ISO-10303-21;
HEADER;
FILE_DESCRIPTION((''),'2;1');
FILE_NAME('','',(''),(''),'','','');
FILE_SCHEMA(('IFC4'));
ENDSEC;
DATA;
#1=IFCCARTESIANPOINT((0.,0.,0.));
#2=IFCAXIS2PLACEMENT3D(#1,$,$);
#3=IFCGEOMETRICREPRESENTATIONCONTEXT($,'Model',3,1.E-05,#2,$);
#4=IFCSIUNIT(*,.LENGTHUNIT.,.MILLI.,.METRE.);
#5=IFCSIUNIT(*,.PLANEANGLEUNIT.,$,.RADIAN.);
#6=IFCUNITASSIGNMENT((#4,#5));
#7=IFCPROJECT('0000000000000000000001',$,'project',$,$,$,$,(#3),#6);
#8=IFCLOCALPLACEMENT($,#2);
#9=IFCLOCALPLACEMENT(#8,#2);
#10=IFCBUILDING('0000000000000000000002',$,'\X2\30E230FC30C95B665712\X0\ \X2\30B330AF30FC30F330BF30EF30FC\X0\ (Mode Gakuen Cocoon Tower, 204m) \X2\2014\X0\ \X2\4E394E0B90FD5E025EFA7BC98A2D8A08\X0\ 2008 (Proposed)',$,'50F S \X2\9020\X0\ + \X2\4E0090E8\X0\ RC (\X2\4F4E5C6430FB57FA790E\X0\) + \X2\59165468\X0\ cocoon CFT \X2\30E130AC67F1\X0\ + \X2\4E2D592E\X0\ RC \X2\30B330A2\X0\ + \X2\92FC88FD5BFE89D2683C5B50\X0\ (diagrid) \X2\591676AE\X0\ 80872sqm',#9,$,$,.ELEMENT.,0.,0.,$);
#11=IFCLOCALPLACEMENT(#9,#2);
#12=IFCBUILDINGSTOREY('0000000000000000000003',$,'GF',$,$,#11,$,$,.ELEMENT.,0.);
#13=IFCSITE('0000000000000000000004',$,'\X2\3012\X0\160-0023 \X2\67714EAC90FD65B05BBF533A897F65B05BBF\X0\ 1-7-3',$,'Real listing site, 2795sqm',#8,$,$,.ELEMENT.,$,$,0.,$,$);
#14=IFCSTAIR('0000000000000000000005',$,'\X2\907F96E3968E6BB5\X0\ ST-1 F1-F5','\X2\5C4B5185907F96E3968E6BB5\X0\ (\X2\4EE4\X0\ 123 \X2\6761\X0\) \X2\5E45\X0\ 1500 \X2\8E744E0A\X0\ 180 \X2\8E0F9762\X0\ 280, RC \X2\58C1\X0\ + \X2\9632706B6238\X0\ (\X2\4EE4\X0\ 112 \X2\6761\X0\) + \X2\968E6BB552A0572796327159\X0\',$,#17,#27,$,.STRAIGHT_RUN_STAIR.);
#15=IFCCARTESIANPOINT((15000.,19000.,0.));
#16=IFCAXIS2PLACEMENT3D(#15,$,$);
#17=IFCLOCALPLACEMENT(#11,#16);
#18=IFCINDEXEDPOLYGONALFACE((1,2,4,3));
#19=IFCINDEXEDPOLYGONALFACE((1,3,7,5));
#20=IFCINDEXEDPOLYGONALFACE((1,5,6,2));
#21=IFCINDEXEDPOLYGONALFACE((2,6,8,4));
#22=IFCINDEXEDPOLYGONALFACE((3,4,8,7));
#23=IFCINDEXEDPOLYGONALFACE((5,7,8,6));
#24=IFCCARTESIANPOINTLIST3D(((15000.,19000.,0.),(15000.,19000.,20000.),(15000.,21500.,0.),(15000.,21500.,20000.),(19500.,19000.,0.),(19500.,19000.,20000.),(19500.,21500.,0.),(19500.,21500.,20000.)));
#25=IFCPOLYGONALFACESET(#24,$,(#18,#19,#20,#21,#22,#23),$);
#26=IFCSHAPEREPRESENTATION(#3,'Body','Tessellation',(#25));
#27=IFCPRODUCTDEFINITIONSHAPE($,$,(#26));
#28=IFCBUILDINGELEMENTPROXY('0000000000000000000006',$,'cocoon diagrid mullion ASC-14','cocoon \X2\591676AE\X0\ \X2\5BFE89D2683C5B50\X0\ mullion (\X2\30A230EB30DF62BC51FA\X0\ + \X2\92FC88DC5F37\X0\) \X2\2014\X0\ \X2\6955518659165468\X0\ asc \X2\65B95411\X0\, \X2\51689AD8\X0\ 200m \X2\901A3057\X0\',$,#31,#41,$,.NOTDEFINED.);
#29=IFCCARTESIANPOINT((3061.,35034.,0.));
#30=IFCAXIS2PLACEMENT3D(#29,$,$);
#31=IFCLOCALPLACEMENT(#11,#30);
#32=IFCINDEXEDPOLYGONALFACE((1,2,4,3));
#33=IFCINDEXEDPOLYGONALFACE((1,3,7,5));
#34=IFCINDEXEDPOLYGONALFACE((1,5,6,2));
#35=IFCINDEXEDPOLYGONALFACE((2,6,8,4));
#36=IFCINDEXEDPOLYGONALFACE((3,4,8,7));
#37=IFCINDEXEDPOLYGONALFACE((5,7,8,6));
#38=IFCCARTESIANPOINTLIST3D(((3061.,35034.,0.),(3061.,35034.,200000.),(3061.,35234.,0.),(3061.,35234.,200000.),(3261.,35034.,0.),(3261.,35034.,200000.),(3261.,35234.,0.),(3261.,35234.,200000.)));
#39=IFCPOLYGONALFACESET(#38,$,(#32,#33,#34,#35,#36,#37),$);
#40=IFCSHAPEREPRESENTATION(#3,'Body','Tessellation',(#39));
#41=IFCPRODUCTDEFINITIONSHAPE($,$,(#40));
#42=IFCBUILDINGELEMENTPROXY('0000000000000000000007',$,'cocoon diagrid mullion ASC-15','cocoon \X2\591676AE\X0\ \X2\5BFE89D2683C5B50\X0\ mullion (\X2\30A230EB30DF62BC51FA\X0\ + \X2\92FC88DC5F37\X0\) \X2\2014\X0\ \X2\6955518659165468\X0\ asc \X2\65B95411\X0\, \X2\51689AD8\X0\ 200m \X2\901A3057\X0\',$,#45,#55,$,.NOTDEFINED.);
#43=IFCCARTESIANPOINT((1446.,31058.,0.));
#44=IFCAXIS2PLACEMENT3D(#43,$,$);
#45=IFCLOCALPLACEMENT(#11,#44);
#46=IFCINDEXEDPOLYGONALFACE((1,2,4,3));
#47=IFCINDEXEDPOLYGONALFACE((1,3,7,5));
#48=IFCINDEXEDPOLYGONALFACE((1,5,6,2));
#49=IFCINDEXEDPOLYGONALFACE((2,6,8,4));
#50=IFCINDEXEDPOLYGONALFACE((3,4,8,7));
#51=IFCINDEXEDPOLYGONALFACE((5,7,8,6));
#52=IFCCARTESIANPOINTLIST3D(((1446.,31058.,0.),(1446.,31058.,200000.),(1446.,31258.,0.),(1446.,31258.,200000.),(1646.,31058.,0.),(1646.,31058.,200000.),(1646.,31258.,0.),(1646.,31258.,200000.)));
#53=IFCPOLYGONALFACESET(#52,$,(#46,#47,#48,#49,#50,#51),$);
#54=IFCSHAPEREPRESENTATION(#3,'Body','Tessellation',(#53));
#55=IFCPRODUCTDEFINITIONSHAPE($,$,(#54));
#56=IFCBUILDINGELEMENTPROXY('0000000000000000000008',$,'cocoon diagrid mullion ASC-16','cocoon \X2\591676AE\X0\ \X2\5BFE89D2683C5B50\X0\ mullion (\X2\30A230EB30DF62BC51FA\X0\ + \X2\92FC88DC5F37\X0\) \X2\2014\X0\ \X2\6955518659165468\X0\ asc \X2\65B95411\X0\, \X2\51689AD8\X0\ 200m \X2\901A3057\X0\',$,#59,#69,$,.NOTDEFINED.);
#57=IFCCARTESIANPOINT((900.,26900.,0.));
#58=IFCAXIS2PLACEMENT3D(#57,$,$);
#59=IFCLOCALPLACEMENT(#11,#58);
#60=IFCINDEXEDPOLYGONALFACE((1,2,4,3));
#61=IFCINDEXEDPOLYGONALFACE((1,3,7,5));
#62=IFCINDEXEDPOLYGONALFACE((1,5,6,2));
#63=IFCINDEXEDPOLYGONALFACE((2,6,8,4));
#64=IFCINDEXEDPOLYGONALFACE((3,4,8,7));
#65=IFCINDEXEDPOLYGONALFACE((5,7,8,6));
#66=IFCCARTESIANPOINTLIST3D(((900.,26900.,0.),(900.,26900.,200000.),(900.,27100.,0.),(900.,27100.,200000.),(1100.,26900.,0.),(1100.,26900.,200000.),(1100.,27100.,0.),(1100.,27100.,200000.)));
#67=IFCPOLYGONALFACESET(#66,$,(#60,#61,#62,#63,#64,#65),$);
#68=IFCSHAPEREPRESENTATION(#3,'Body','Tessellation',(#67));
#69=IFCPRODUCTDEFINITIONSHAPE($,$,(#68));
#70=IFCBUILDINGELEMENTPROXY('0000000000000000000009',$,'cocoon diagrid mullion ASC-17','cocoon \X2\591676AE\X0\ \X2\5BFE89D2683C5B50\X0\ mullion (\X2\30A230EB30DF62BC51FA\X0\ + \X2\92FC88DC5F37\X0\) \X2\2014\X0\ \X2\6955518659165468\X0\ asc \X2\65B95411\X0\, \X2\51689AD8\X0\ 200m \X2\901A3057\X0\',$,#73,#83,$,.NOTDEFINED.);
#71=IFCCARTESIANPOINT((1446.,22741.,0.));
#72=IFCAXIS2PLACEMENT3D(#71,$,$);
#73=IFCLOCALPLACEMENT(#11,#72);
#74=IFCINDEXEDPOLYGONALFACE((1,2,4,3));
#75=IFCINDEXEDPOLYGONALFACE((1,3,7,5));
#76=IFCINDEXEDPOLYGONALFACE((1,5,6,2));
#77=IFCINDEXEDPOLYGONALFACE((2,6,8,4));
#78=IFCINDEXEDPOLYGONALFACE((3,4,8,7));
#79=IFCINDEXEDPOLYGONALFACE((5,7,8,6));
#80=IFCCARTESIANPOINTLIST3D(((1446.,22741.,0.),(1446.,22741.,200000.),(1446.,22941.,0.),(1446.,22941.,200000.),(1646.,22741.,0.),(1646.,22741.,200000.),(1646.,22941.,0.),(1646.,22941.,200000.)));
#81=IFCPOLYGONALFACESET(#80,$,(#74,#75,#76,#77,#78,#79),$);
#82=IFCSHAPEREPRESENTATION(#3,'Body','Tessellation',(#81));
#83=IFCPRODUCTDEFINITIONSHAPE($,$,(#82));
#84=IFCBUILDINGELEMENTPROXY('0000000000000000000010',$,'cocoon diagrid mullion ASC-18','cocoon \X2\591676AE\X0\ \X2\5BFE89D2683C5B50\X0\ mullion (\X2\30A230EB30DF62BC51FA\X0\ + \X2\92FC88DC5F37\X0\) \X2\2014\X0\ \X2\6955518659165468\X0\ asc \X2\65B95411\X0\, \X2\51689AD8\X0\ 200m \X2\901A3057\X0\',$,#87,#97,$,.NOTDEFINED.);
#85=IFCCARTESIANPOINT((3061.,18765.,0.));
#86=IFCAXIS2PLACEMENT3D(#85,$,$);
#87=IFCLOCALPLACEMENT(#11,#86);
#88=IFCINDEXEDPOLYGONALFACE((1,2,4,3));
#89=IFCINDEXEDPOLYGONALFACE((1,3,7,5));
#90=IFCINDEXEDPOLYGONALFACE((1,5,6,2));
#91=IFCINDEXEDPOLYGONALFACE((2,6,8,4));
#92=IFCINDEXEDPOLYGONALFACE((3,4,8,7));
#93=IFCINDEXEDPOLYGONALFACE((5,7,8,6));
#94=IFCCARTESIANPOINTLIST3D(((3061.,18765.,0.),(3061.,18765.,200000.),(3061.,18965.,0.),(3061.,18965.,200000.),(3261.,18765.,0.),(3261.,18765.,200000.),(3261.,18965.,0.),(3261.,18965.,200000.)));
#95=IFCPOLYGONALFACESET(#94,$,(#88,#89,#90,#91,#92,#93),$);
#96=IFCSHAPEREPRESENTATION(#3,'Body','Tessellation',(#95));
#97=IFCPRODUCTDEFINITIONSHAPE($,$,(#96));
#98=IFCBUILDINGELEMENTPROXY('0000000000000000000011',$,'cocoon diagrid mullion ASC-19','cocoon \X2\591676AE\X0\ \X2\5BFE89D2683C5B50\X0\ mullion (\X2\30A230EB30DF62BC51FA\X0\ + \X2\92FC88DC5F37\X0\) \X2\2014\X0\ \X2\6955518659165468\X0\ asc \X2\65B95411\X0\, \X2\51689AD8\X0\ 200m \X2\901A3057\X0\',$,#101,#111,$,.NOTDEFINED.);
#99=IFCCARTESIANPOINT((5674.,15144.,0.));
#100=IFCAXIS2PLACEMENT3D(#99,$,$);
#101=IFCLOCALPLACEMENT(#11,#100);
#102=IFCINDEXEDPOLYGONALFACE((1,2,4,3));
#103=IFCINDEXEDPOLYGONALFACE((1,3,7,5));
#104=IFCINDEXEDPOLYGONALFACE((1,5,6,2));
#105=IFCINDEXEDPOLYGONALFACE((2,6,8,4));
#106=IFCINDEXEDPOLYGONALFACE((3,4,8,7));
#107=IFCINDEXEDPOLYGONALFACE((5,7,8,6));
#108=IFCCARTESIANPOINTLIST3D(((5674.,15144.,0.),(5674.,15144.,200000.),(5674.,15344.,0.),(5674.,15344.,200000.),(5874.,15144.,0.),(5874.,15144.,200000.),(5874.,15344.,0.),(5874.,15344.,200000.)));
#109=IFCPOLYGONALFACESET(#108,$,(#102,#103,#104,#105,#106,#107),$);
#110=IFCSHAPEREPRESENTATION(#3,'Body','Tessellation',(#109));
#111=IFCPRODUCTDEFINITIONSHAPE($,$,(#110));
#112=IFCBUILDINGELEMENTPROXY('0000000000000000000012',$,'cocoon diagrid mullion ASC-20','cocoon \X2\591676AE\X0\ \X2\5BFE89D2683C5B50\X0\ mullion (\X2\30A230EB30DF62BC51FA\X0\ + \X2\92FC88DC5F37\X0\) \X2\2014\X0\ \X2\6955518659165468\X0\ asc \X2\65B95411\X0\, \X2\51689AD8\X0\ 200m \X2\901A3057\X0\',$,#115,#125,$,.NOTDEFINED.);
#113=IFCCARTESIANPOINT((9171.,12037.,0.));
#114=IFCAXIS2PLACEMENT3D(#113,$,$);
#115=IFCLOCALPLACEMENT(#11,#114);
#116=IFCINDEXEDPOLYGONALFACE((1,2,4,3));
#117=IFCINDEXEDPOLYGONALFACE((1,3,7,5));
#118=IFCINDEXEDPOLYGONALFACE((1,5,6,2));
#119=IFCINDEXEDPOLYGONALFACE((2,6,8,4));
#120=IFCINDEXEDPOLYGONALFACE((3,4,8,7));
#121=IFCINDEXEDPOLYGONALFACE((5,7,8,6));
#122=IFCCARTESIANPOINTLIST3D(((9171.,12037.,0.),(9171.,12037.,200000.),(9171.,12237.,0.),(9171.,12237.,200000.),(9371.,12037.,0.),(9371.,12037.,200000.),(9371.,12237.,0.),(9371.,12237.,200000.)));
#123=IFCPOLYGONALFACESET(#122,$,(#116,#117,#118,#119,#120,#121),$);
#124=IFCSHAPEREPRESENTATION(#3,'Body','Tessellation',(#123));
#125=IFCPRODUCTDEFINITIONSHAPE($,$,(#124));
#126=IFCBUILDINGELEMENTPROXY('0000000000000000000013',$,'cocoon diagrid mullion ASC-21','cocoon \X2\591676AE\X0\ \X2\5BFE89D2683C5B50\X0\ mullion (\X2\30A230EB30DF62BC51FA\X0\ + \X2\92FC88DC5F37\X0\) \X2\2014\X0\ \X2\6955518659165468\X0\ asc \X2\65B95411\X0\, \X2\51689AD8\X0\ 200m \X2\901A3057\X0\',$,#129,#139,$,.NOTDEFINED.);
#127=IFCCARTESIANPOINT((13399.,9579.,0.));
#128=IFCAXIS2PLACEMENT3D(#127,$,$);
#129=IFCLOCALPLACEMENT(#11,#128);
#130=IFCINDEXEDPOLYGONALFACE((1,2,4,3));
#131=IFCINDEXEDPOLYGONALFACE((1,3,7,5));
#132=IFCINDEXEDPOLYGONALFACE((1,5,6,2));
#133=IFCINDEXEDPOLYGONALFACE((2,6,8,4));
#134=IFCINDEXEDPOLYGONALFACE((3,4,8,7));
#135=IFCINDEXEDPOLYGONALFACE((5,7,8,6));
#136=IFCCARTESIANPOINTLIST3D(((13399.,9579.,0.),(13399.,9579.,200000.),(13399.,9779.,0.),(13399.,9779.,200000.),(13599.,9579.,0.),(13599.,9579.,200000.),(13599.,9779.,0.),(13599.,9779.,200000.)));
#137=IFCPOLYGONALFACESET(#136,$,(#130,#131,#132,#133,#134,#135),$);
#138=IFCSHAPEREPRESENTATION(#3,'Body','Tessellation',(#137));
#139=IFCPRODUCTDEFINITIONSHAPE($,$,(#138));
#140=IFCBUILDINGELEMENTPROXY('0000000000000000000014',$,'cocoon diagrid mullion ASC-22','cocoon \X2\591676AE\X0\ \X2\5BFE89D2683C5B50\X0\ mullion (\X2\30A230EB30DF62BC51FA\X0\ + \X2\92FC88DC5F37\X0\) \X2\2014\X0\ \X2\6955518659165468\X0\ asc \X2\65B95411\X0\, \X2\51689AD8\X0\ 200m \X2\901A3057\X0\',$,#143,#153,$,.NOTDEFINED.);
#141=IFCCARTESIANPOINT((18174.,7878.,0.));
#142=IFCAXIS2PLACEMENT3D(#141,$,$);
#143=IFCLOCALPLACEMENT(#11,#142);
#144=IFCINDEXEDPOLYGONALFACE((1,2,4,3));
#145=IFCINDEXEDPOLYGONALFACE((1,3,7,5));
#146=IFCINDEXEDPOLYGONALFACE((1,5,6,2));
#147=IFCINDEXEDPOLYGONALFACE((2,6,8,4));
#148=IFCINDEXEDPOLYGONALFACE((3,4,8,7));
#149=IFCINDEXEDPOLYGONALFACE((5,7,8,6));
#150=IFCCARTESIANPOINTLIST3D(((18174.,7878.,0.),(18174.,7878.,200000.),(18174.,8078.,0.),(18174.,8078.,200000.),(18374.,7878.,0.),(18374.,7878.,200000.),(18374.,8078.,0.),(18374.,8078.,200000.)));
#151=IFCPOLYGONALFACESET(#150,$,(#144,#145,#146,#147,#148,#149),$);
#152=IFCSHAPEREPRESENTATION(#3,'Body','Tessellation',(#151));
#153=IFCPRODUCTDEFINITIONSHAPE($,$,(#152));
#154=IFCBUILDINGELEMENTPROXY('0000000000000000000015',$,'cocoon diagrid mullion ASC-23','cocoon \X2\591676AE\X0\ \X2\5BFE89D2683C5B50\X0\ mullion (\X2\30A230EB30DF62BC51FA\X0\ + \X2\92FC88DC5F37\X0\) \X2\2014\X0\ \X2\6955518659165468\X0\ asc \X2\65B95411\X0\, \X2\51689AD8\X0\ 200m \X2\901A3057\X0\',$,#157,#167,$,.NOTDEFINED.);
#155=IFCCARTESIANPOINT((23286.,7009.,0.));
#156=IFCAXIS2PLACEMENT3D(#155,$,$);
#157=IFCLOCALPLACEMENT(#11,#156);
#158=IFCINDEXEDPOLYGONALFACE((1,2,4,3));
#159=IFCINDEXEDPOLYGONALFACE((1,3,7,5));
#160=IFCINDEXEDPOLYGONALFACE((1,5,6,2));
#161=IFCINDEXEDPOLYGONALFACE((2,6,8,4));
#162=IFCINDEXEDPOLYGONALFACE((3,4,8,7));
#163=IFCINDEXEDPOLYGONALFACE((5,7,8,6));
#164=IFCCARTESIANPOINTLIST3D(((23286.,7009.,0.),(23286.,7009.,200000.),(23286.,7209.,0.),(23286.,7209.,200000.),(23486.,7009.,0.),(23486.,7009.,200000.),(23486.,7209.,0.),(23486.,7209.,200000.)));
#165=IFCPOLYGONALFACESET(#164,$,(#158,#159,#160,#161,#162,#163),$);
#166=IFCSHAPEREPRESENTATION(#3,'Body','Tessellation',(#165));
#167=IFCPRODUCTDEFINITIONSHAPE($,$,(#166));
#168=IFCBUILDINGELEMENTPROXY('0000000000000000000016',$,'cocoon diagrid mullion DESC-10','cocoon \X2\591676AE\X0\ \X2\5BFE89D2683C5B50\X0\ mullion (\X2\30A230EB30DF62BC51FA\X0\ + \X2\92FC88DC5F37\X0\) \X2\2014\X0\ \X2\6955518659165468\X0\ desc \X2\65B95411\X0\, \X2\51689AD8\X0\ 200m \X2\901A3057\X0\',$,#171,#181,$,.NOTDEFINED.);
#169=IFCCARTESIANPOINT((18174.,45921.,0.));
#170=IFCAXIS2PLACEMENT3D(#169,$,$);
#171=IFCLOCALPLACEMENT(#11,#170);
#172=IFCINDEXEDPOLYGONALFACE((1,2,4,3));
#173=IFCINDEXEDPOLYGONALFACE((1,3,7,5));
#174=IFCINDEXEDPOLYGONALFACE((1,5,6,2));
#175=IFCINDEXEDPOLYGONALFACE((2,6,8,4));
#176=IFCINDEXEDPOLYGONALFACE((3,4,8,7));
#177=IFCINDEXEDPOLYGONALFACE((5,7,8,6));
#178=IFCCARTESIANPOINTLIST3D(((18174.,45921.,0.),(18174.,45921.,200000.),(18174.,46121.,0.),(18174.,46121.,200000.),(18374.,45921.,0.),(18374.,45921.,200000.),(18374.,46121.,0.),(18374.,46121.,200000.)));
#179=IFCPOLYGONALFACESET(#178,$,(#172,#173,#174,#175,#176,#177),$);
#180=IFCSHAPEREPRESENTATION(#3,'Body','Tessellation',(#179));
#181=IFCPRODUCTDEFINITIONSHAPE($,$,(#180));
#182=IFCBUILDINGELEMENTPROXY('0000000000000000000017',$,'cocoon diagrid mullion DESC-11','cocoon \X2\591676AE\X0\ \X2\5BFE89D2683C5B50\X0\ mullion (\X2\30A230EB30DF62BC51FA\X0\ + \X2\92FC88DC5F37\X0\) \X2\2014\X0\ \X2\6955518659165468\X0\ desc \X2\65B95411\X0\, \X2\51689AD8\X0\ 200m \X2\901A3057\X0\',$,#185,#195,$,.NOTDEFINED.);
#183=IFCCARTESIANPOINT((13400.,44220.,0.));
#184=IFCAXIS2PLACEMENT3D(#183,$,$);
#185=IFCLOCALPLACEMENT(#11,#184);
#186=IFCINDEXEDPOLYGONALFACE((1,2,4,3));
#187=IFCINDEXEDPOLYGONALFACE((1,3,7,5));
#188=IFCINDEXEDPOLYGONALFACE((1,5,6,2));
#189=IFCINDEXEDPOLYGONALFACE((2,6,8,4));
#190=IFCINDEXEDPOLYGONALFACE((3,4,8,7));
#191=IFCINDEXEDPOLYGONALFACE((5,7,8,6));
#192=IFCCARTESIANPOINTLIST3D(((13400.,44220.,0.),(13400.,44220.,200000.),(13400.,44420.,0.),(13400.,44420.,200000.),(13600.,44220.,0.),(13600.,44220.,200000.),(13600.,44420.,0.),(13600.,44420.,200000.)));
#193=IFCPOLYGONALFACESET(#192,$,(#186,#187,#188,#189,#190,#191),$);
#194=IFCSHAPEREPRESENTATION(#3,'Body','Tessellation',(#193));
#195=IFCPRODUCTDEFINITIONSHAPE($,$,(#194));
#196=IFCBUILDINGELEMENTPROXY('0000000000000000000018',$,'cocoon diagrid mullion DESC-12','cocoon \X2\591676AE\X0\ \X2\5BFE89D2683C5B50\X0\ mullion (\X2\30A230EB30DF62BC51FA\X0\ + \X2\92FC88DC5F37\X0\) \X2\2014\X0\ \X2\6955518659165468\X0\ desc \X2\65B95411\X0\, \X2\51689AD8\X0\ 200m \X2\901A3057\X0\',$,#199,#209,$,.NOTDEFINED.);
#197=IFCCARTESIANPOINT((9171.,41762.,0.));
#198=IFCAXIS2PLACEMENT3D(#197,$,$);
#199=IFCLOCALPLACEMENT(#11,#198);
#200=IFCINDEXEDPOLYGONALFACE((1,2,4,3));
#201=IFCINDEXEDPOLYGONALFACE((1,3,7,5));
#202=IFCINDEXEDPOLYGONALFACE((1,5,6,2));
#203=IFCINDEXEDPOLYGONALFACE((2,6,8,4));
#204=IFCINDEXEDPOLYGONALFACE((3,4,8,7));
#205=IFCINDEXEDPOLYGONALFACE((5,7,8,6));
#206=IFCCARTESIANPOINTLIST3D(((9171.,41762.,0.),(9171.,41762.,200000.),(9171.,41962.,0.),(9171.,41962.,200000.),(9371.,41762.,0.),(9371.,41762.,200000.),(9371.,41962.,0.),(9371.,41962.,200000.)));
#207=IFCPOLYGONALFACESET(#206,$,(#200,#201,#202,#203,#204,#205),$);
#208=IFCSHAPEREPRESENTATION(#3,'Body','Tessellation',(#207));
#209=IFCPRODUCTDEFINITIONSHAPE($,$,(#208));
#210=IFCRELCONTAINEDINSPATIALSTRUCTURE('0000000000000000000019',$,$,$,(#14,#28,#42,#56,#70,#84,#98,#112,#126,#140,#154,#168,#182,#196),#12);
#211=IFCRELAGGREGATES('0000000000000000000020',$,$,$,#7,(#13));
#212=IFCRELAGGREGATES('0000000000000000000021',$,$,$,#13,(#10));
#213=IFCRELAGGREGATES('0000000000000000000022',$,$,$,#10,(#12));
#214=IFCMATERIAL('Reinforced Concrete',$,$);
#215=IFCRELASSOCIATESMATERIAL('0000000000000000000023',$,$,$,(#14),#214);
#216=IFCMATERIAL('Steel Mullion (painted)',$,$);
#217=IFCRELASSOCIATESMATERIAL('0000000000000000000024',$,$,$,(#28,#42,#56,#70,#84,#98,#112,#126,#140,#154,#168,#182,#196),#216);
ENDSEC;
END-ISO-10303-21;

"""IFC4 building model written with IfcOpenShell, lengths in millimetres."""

from ifc_helpers import new_model, si_unit, frame, frame_2d, origin, place, context, project, spatial, rectangle, extrude, material, element, save


model = new_model("IFC4")

# Units and contexts
model_context = context("Model", 3, precision=1e-05, world=origin())
ifc_project = project(units=[si_unit("LENGTHUNIT", "METRE", prefix="MILLI"), si_unit("PLANEANGLEUNIT", "RADIAN")], contexts=[model_context])

# Site, building, storey
site_placement = place(None, origin())
site = spatial("IfcSite", under=ifc_project, at=site_placement, Name="〒160-0023 東京都新宿区西新宿 1-7-3", ObjectType="Real listing site, 2795sqm", CompositionType="ELEMENT", RefElevation=0.0)
building_placement = place(site_placement, origin())
building = spatial("IfcBuilding", under=site, at=building_placement, Name="モード学園 コクーンタワー (Mode Gakuen Cocoon Tower, 204m) — 丹下都市建築設計 2008 (Proposed)", ObjectType="50F S 造 + 一部 RC (低層・基礎) + 外周 cocoon CFT メガ柱 + 中央 RC コア + 鋼製対角格子 (diagrid) 外皮 80872sqm", CompositionType="ELEMENT", ElevationOfRefHeight=0.0, ElevationOfTerrain=0.0)
storey_placement = place(building_placement, origin())
storey = spatial("IfcBuildingStorey", under=building, at=storey_placement, Name="GF", CompositionType="ELEMENT", Elevation=0.0)

# Stair
ifc_material_1 = material(Name="Reinforced Concrete")
stair_placement = place(storey_placement, frame((15000.0, 19000.0, 0.0)))
element("IfcStair", 1, at=stair_placement, inside=storey, material=ifc_material_1, Name="避難階段 ST-1 F1-F5", Description="屋内避難階段 (令 123 条) 幅 1500 蹴上 180 踏面 280, RC 壁 + 防火戸 (令 112 条) + 階段加圧防煙", PredefinedType="STRAIGHT_RUN_STAIR", context=model_context, shape_type="SweptSolid", body=[
    extrude(rectangle(XDim=4500.0, YDim=2500.0, at=frame_2d((2250.0, 1250.0))), frame((15000.0, 19000.0, 0.0)), (0.0, 0.0, 1.0), 20000.0),
])

# Building element proxies
ifc_material_2 = material(Name="Steel Mullion (painted)")
proxy_1_placement = place(storey_placement, frame((3061.0, 35034.0, 0.0)))
element("IfcBuildingElementProxy", 2, at=proxy_1_placement, inside=storey, material=ifc_material_2, Name="cocoon diagrid mullion ASC-14", Description="cocoon 外皮 対角格子 mullion (アルミ押出 + 鋼補強) — 楕円外周 asc 方向, 全高 200m 通し", PredefinedType="NOTDEFINED", context=model_context, shape_type="SweptSolid", body=[
    extrude(rectangle(XDim=200.0, YDim=200.0, at=frame_2d((100.0, 100.0))), frame((3061.0, 35034.0, 0.0)), (0.0, 0.0, 1.0), 200000.0),
])
proxy_2_placement = place(storey_placement, frame((1446.0, 31058.0, 0.0)))
element("IfcBuildingElementProxy", 3, at=proxy_2_placement, inside=storey, material=ifc_material_2, Name="cocoon diagrid mullion ASC-15", Description="cocoon 外皮 対角格子 mullion (アルミ押出 + 鋼補強) — 楕円外周 asc 方向, 全高 200m 通し", PredefinedType="NOTDEFINED", context=model_context, shape_type="SweptSolid", body=[
    extrude(rectangle(XDim=200.0, YDim=200.0, at=frame_2d((100.0, 100.0))), frame((1446.0, 31058.0, 0.0)), (0.0, 0.0, 1.0), 200000.0),
])
proxy_3_placement = place(storey_placement, frame((900.0, 26900.0, 0.0)))
element("IfcBuildingElementProxy", 4, at=proxy_3_placement, inside=storey, material=ifc_material_2, Name="cocoon diagrid mullion ASC-16", Description="cocoon 外皮 対角格子 mullion (アルミ押出 + 鋼補強) — 楕円外周 asc 方向, 全高 200m 通し", PredefinedType="NOTDEFINED", context=model_context, shape_type="SweptSolid", body=[
    extrude(rectangle(XDim=200.0, YDim=200.0, at=frame_2d((100.0, 100.0))), frame((900.0, 26900.0, 0.0)), (0.0, 0.0, 1.0), 200000.0),
])
proxy_4_placement = place(storey_placement, frame((1446.0, 22741.0, 0.0)))
element("IfcBuildingElementProxy", 5, at=proxy_4_placement, inside=storey, material=ifc_material_2, Name="cocoon diagrid mullion ASC-17", Description="cocoon 外皮 対角格子 mullion (アルミ押出 + 鋼補強) — 楕円外周 asc 方向, 全高 200m 通し", PredefinedType="NOTDEFINED", context=model_context, shape_type="SweptSolid", body=[
    extrude(rectangle(XDim=200.0, YDim=200.0, at=frame_2d((100.0, 100.0))), frame((1446.0, 22741.0, 0.0)), (0.0, 0.0, 1.0), 200000.0),
])
proxy_5_placement = place(storey_placement, frame((3061.0, 18765.0, 0.0)))
element("IfcBuildingElementProxy", 6, at=proxy_5_placement, inside=storey, material=ifc_material_2, Name="cocoon diagrid mullion ASC-18", Description="cocoon 外皮 対角格子 mullion (アルミ押出 + 鋼補強) — 楕円外周 asc 方向, 全高 200m 通し", PredefinedType="NOTDEFINED", context=model_context, shape_type="SweptSolid", body=[
    extrude(rectangle(XDim=200.0, YDim=200.0, at=frame_2d((100.0, 100.0))), frame((3061.0, 18765.0, 0.0)), (0.0, 0.0, 1.0), 200000.0),
])
proxy_6_placement = place(storey_placement, frame((5674.0, 15144.0, 0.0)))
element("IfcBuildingElementProxy", 7, at=proxy_6_placement, inside=storey, material=ifc_material_2, Name="cocoon diagrid mullion ASC-19", Description="cocoon 外皮 対角格子 mullion (アルミ押出 + 鋼補強) — 楕円外周 asc 方向, 全高 200m 通し", PredefinedType="NOTDEFINED", context=model_context, shape_type="SweptSolid", body=[
    extrude(rectangle(XDim=200.0, YDim=200.0, at=frame_2d((100.0, 100.0))), frame((5674.0, 15144.0, 0.0)), (0.0, 0.0, 1.0), 200000.0),
])
proxy_7_placement = place(storey_placement, frame((9171.0, 12037.0, 0.0)))
element("IfcBuildingElementProxy", 8, at=proxy_7_placement, inside=storey, material=ifc_material_2, Name="cocoon diagrid mullion ASC-20", Description="cocoon 外皮 対角格子 mullion (アルミ押出 + 鋼補強) — 楕円外周 asc 方向, 全高 200m 通し", PredefinedType="NOTDEFINED", context=model_context, shape_type="SweptSolid", body=[
    extrude(rectangle(XDim=200.0, YDim=200.0, at=frame_2d((100.0, 100.0))), frame((9171.0, 12037.0, 0.0)), (0.0, 0.0, 1.0), 200000.0),
])
proxy_8_placement = place(storey_placement, frame((13399.0, 9579.0, 0.0)))
element("IfcBuildingElementProxy", 9, at=proxy_8_placement, inside=storey, material=ifc_material_2, Name="cocoon diagrid mullion ASC-21", Description="cocoon 外皮 対角格子 mullion (アルミ押出 + 鋼補強) — 楕円外周 asc 方向, 全高 200m 通し", PredefinedType="NOTDEFINED", context=model_context, shape_type="SweptSolid", body=[
    extrude(rectangle(XDim=200.0, YDim=200.0, at=frame_2d((100.0, 100.0))), frame((13399.0, 9579.0, 0.0)), (0.0, 0.0, 1.0), 200000.0),
])
proxy_9_placement = place(storey_placement, frame((18174.0, 7878.0, 0.0)))
element("IfcBuildingElementProxy", 10, at=proxy_9_placement, inside=storey, material=ifc_material_2, Name="cocoon diagrid mullion ASC-22", Description="cocoon 外皮 対角格子 mullion (アルミ押出 + 鋼補強) — 楕円外周 asc 方向, 全高 200m 通し", PredefinedType="NOTDEFINED", context=model_context, shape_type="SweptSolid", body=[
    extrude(rectangle(XDim=200.0, YDim=200.0, at=frame_2d((100.0, 100.0))), frame((18174.0, 7878.0, 0.0)), (0.0, 0.0, 1.0), 200000.0),
])
proxy_10_placement = place(storey_placement, frame((23286.0, 7009.0, 0.0)))
element("IfcBuildingElementProxy", 11, at=proxy_10_placement, inside=storey, material=ifc_material_2, Name="cocoon diagrid mullion ASC-23", Description="cocoon 外皮 対角格子 mullion (アルミ押出 + 鋼補強) — 楕円外周 asc 方向, 全高 200m 通し", PredefinedType="NOTDEFINED", context=model_context, shape_type="SweptSolid", body=[
    extrude(rectangle(XDim=200.0, YDim=200.0, at=frame_2d((100.0, 100.0))), frame((23286.0, 7009.0, 0.0)), (0.0, 0.0, 1.0), 200000.0),
])
proxy_11_placement = place(storey_placement, frame((18174.0, 45921.0, 0.0)))
element("IfcBuildingElementProxy", 12, at=proxy_11_placement, inside=storey, material=ifc_material_2, Name="cocoon diagrid mullion DESC-10", Description="cocoon 外皮 対角格子 mullion (アルミ押出 + 鋼補強) — 楕円外周 desc 方向, 全高 200m 通し", PredefinedType="NOTDEFINED", context=model_context, shape_type="SweptSolid", body=[
    extrude(rectangle(XDim=200.0, YDim=200.0, at=frame_2d((100.0, 100.0))), frame((18174.0, 45921.0, 0.0)), (0.0, 0.0, 1.0), 200000.0),
])
proxy_12_placement = place(storey_placement, frame((13400.0, 44220.0, 0.0)))
element("IfcBuildingElementProxy", 13, at=proxy_12_placement, inside=storey, material=ifc_material_2, Name="cocoon diagrid mullion DESC-11", Description="cocoon 外皮 対角格子 mullion (アルミ押出 + 鋼補強) — 楕円外周 desc 方向, 全高 200m 通し", PredefinedType="NOTDEFINED", context=model_context, shape_type="SweptSolid", body=[
    extrude(rectangle(XDim=200.0, YDim=200.0, at=frame_2d((100.0, 100.0))), frame((13400.0, 44220.0, 0.0)), (0.0, 0.0, 1.0), 200000.0),
])
proxy_13_placement = place(storey_placement, frame((9171.0, 41762.0, 0.0)))
element("IfcBuildingElementProxy", 14, at=proxy_13_placement, inside=storey, material=ifc_material_2, Name="cocoon diagrid mullion DESC-12", Description="cocoon 外皮 対角格子 mullion (アルミ押出 + 鋼補強) — 楕円外周 desc 方向, 全高 200m 通し", PredefinedType="NOTDEFINED", context=model_context, shape_type="SweptSolid", body=[
    extrude(rectangle(XDim=200.0, YDim=200.0, at=frame_2d((100.0, 100.0))), frame((9171.0, 41762.0, 0.0)), (0.0, 0.0, 1.0), 200000.0),
])

save(model, "model.ifc")
